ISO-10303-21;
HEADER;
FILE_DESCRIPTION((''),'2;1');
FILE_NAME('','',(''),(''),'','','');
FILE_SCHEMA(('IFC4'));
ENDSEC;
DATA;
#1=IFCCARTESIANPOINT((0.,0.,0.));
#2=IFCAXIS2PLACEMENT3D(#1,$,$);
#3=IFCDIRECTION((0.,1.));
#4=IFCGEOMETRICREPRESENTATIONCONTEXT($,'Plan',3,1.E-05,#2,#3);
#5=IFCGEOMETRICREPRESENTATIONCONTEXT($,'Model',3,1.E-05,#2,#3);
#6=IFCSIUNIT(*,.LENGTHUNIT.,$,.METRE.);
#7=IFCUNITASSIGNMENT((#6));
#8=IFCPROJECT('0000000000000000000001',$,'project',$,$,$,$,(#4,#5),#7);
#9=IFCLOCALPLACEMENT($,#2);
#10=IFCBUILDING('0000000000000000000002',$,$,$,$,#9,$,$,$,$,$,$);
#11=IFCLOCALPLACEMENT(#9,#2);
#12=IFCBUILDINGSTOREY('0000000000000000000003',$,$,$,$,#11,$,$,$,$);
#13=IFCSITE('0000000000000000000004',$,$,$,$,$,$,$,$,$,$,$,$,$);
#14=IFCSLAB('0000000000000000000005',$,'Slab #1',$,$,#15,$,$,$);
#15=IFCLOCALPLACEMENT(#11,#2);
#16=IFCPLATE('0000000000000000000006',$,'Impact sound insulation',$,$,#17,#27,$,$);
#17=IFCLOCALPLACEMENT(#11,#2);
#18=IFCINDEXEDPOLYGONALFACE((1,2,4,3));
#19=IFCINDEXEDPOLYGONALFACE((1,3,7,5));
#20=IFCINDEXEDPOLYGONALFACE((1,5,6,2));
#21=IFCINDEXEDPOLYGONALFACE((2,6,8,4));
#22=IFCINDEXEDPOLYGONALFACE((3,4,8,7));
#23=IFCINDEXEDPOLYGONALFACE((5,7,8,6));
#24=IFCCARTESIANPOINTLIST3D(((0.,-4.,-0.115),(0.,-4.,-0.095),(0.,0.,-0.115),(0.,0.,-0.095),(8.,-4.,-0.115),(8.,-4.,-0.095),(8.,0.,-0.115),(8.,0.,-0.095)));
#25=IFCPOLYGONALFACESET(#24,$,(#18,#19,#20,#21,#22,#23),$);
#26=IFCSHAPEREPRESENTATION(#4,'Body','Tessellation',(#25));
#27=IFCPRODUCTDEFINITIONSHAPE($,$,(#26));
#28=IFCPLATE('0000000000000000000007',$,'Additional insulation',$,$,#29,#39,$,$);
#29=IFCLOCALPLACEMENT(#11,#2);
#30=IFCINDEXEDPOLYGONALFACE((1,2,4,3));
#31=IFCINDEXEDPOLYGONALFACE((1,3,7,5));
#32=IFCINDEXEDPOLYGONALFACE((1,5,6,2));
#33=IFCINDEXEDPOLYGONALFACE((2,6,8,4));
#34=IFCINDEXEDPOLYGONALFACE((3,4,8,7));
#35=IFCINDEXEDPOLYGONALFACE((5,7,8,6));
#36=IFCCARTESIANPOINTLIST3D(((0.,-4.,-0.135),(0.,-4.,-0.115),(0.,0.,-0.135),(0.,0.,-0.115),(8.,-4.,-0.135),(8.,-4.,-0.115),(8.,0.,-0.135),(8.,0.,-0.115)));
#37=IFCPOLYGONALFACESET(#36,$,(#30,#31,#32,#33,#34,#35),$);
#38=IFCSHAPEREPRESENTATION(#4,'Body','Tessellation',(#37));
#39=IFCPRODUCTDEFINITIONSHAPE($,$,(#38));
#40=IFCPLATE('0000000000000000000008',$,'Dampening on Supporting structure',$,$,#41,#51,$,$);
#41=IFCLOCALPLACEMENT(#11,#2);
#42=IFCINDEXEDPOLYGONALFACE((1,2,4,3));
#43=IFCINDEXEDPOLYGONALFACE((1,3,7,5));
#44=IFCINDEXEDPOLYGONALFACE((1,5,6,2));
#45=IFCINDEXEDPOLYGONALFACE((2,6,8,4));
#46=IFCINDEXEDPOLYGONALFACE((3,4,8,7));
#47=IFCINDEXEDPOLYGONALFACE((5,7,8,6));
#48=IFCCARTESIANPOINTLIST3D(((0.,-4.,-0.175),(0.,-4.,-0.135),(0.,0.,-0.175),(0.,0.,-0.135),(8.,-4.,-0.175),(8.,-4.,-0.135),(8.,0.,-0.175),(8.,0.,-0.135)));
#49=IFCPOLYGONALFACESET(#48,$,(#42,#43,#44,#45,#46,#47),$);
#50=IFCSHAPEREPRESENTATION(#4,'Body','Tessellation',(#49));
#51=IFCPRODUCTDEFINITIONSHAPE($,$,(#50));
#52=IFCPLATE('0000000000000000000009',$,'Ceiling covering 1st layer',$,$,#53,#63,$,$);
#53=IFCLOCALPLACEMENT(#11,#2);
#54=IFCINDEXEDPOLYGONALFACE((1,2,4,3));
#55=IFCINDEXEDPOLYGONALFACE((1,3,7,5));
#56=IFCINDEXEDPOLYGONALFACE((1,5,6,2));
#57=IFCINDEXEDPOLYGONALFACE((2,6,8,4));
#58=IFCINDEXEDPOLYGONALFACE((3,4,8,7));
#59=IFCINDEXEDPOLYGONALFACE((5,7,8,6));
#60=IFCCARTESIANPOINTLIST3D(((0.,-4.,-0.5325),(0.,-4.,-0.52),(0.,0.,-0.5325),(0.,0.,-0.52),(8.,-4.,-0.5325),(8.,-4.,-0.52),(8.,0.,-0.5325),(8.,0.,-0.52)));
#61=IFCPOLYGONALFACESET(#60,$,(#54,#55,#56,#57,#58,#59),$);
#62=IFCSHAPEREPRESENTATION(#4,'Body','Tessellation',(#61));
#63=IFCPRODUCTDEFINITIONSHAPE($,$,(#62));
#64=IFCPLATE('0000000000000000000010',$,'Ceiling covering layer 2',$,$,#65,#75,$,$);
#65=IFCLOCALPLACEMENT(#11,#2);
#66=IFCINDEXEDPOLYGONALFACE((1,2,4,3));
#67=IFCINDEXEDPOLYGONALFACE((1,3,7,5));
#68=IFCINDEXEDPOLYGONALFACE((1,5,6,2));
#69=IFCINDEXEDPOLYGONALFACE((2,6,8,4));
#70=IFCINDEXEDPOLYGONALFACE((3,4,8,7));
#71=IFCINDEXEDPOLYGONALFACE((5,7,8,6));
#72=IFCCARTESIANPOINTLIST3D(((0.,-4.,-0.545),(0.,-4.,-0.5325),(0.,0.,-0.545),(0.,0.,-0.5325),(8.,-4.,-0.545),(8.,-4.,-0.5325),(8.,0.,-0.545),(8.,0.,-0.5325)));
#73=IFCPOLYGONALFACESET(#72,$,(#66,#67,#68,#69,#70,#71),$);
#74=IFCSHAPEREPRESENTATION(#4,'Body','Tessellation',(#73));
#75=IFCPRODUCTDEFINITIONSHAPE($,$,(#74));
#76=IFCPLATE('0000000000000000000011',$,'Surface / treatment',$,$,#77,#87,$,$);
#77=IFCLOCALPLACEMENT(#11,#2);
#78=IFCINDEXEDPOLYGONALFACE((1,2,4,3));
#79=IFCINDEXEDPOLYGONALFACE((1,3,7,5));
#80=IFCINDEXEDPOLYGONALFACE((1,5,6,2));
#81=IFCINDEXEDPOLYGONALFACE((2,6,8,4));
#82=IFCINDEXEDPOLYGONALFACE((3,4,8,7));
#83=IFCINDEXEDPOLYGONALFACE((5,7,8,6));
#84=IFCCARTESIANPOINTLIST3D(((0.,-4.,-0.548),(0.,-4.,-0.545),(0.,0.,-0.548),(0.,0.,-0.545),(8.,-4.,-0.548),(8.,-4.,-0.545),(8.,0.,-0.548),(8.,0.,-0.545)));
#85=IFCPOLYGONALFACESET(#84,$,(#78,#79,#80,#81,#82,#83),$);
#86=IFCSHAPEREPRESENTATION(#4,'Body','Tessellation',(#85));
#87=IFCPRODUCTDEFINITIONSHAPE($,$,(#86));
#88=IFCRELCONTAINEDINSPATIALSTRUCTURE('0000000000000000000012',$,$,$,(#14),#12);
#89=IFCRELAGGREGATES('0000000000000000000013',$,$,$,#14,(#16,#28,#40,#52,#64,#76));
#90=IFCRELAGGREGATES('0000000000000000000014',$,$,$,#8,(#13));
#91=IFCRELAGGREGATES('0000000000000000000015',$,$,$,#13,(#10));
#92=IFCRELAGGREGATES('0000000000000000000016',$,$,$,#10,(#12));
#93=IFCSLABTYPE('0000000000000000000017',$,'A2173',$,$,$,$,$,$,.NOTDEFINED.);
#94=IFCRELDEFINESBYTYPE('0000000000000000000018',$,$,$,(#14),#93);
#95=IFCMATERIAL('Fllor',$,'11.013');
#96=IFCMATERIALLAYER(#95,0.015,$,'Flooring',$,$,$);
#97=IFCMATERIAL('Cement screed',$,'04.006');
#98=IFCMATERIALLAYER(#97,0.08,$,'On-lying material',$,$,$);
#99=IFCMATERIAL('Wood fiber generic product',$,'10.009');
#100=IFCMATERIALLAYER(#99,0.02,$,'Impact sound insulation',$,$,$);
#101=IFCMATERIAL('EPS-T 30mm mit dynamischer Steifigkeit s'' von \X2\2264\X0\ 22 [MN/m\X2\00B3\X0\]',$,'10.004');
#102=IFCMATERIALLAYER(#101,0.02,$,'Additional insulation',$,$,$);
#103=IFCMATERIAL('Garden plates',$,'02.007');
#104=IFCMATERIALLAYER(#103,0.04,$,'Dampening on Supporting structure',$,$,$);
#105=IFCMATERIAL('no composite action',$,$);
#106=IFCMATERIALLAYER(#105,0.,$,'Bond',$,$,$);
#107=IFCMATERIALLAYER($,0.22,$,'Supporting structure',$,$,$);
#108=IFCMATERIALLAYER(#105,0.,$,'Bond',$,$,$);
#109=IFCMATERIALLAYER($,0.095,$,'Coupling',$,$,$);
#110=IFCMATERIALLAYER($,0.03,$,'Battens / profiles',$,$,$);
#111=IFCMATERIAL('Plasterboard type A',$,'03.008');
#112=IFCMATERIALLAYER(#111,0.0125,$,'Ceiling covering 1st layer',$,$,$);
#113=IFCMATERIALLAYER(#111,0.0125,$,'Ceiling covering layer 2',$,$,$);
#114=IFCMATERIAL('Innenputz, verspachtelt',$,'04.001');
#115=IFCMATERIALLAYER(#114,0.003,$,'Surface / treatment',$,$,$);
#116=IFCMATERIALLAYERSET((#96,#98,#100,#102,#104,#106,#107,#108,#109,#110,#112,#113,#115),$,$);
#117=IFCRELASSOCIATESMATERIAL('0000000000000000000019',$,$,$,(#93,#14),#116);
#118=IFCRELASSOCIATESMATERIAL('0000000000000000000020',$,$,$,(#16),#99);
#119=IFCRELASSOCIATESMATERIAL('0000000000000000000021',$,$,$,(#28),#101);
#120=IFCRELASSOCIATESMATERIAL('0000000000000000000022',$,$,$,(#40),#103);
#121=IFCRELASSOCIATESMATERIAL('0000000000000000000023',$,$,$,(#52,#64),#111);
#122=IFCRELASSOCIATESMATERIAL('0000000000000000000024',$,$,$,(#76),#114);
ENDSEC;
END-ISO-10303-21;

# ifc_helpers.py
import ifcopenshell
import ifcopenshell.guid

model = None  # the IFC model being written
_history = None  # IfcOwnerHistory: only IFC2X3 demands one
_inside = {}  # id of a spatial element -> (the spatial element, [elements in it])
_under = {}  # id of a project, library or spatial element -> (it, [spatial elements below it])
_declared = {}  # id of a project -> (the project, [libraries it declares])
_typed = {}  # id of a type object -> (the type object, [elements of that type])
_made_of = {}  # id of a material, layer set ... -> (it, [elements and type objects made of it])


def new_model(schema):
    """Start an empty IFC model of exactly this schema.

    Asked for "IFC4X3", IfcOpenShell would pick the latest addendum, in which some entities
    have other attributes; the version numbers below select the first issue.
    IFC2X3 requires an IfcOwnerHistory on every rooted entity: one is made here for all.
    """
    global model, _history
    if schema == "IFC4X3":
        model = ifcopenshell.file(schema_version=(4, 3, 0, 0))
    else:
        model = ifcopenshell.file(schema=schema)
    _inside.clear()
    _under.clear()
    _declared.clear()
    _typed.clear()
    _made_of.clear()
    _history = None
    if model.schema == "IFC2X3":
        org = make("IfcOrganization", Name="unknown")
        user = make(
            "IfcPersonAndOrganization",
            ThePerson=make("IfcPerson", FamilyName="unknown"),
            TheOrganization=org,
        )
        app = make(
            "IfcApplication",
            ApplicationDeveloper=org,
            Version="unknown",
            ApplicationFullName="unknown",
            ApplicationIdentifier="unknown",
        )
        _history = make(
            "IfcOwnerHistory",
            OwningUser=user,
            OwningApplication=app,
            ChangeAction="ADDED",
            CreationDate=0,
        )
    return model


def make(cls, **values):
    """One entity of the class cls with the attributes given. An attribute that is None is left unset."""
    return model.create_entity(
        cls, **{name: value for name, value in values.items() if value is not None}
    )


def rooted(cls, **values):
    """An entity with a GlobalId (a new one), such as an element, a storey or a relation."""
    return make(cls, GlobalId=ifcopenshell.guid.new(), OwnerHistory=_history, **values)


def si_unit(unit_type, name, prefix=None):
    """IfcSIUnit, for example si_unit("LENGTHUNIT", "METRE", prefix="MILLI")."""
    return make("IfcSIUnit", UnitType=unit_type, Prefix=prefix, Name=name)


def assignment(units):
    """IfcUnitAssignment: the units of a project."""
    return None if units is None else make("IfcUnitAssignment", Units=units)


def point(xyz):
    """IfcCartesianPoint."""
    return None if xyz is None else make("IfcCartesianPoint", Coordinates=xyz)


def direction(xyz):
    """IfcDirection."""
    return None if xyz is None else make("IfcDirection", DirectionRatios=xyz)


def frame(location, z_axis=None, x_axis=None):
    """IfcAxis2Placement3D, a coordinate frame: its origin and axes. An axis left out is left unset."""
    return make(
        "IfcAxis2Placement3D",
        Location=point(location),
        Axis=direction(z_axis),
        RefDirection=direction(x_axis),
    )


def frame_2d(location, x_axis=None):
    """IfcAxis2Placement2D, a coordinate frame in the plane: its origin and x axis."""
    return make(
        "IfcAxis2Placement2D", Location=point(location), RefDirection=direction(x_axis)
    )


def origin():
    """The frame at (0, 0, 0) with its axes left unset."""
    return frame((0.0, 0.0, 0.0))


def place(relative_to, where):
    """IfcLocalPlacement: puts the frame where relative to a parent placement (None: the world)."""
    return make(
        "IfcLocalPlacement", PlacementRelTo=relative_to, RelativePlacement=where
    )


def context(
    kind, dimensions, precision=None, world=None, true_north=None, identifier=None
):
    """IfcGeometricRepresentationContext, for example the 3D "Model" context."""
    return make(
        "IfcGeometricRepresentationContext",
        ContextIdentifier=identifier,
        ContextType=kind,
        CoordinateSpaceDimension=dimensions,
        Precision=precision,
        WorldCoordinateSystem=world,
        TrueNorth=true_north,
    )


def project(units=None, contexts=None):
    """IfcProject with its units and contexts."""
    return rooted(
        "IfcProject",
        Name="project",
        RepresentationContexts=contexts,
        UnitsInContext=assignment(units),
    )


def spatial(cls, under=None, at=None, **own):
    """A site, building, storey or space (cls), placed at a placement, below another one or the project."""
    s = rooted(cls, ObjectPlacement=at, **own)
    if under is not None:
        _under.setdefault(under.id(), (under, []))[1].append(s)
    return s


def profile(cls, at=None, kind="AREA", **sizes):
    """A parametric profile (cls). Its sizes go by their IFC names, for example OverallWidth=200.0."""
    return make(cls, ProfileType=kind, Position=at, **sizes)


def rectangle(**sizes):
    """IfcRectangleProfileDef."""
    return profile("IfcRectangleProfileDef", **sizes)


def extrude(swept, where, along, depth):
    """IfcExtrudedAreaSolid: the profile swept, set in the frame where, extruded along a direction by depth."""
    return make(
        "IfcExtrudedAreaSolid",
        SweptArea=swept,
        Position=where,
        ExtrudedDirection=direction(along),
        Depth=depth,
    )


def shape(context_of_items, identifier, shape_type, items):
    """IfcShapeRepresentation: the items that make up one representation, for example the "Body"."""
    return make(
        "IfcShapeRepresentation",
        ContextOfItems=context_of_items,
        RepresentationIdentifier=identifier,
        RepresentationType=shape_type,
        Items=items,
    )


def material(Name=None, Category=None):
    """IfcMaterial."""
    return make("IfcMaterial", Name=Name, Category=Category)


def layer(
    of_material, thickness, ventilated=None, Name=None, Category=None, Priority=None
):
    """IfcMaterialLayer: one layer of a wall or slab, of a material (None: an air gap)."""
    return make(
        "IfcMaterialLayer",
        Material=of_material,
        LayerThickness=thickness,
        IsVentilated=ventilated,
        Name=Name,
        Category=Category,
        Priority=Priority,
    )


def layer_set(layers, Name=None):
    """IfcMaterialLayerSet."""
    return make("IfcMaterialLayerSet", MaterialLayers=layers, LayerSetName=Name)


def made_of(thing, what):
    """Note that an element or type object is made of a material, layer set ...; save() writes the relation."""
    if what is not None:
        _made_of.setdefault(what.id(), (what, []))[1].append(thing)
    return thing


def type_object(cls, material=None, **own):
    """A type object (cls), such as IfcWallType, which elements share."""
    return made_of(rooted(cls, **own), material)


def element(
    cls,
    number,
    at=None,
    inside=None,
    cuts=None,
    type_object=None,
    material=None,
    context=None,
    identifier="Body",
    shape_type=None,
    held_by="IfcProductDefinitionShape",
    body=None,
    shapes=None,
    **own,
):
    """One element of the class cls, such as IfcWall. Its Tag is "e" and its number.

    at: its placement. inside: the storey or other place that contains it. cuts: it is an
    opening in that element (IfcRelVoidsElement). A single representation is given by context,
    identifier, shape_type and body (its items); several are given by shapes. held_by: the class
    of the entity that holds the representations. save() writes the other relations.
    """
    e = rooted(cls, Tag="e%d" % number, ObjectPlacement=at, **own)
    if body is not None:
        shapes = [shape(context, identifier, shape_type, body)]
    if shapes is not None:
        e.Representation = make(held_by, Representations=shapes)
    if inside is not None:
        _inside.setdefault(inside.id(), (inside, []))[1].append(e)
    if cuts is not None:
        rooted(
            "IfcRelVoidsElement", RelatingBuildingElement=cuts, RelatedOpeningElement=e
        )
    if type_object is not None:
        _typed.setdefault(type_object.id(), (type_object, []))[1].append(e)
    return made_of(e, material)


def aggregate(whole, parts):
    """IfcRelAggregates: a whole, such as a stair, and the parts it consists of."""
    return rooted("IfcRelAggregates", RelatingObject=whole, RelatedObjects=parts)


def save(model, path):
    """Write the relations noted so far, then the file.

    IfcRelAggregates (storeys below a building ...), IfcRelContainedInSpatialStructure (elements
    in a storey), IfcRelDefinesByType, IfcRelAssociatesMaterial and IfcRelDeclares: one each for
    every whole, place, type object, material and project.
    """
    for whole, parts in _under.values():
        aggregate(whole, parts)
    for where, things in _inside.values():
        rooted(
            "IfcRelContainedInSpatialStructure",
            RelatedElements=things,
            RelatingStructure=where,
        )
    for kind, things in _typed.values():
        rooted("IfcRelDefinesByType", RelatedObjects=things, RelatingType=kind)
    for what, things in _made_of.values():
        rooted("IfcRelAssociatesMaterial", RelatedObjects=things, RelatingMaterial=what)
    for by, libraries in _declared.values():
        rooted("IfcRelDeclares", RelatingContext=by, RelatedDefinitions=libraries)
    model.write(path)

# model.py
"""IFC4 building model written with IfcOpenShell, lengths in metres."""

from ifc_helpers import new_model, si_unit, direction, frame, frame_2d, origin, place, context, project, spatial, rectangle, extrude, material, layer, layer_set, type_object, element, aggregate, save


model = new_model("IFC4")

# Units and contexts
plan_context = context("Plan", 3, precision=1e-05, world=origin(), true_north=direction((0.0, 1.0)))
model_context = context("Model", 3, precision=1e-05, world=origin(), true_north=direction((0.0, 1.0)))
ifc_project = project(units=[si_unit("LENGTHUNIT", "METRE")], contexts=[plan_context, model_context])

# Site, building, storey
site = spatial("IfcSite", under=ifc_project)
building_placement = place(None, origin())
building = spatial("IfcBuilding", under=site, at=building_placement)
storey_placement = place(building_placement, origin())
storey = spatial("IfcBuildingStorey", under=building, at=storey_placement)

# Slab, plates
ifc_material_1 = material(Name="Fllor", Category="11.013")
ifc_layer_1 = layer(ifc_material_1, 0.015, Name="Flooring")
ifc_material_2 = material(Name="Cement screed", Category="04.006")
ifc_layer_2 = layer(ifc_material_2, 0.08, Name="On-lying material")
ifc_material_3 = material(Name="Wood fiber generic product", Category="10.009")
ifc_layer_3 = layer(ifc_material_3, 0.02, Name="Impact sound insulation")
ifc_material_4 = material(Name="EPS-T 30mm mit dynamischer Steifigkeit s' von ≤ 22 [MN/m³]", Category="10.004")
ifc_layer_4 = layer(ifc_material_4, 0.02, Name="Additional insulation")
ifc_material_5 = material(Name="Garden plates", Category="02.007")
ifc_layer_5 = layer(ifc_material_5, 0.04, Name="Dampening on Supporting structure")
ifc_material_6 = material(Name="no composite action")
ifc_layer_6 = layer(ifc_material_6, 0.0, Name="Bond")
ifc_layer_7 = layer(None, 0.22, Name="Supporting structure")
ifc_layer_8 = layer(ifc_material_6, 0.0, Name="Bond")
ifc_layer_9 = layer(None, 0.095, Name="Coupling")
ifc_layer_10 = layer(None, 0.03, Name="Battens / profiles")
ifc_material_7 = material(Name="Plasterboard type A", Category="03.008")
ifc_layer_11 = layer(ifc_material_7, 0.0125, Name="Ceiling covering 1st layer")
ifc_layer_12 = layer(ifc_material_7, 0.0125, Name="Ceiling covering layer 2")
ifc_material_8 = material(Name="Innenputz, verspachtelt", Category="04.001")
ifc_layer_13 = layer(ifc_material_8, 0.003, Name="Surface / treatment")
ifc_layer_set = layer_set([ifc_layer_1, ifc_layer_2, ifc_layer_3, ifc_layer_4, ifc_layer_5, ifc_layer_6, ifc_layer_7, ifc_layer_8, ifc_layer_9, ifc_layer_10, ifc_layer_11, ifc_layer_12, ifc_layer_13])
slab_type = type_object("IfcSlabType", Name="A2173", PredefinedType="NOTDEFINED", material=ifc_layer_set)
slab_placement = place(None, frame((0.0, 0.0, 0.0), z_axis=(0.0, 0.0, -1.0), x_axis=(1.0, 0.0, 0.0)))
slab = element("IfcSlab", 1, at=slab_placement, inside=storey, type_object=slab_type, material=ifc_layer_set, Name="Slab #1")
plate_1_placement = place(slab_placement, origin())
plate_1 = element("IfcPlate", 2, at=plate_1_placement, material=ifc_material_3, Name="Impact sound insulation", context=plan_context, shape_type="SweptSolid", body=[
    extrude(rectangle(XDim=8.0, YDim=4.0, at=frame_2d((4.0, 2.0), x_axis=(1.0, 0.0))), frame((0.0, 0.0, 0.095), z_axis=(0.0, 0.0, 1.0), x_axis=(1.0, 0.0, 0.0)), (0.0, 0.0, 1.0), 0.02),
])
plate_2_placement = place(slab_placement, origin())
plate_2 = element("IfcPlate", 3, at=plate_2_placement, material=ifc_material_4, Name="Additional insulation", context=plan_context, shape_type="SweptSolid", body=[
    extrude(rectangle(XDim=8.0, YDim=4.0, at=frame_2d((4.0, 2.0), x_axis=(1.0, 0.0))), frame((0.0, 0.0, 0.115), z_axis=(0.0, 0.0, 1.0), x_axis=(1.0, 0.0, 0.0)), (0.0, 0.0, 1.0), 0.02),
])
plate_3_placement = place(slab_placement, origin())
plate_3 = element("IfcPlate", 4, at=plate_3_placement, material=ifc_material_5, Name="Dampening on Supporting structure", context=plan_context, shape_type="SweptSolid", body=[
    extrude(rectangle(XDim=8.0, YDim=4.0, at=frame_2d((4.0, 2.0), x_axis=(1.0, 0.0))), frame((0.0, 0.0, 0.135), z_axis=(0.0, 0.0, 1.0), x_axis=(1.0, 0.0, 0.0)), (0.0, 0.0, 1.0), 0.04),
])
plate_4_placement = place(slab_placement, origin())
plate_4 = element("IfcPlate", 5, at=plate_4_placement, material=ifc_material_7, Name="Ceiling covering 1st layer", context=plan_context, shape_type="SweptSolid", body=[
    extrude(rectangle(XDim=8.0, YDim=4.0, at=frame_2d((4.0, 2.0), x_axis=(1.0, 0.0))), frame((0.0, 0.0, 0.52), z_axis=(0.0, 0.0, 1.0), x_axis=(1.0, 0.0, 0.0)), (0.0, 0.0, 1.0), 0.0125),
])
plate_5_placement = place(slab_placement, origin())
plate_5 = element("IfcPlate", 6, at=plate_5_placement, material=ifc_material_7, Name="Ceiling covering layer 2", context=plan_context, shape_type="SweptSolid", body=[
    extrude(rectangle(XDim=8.0, YDim=4.0, at=frame_2d((4.0, 2.0), x_axis=(1.0, 0.0))), frame((0.0, 0.0, 0.5325), z_axis=(0.0, 0.0, 1.0), x_axis=(1.0, 0.0, 0.0)), (0.0, 0.0, 1.0), 0.0125),
])
plate_6_placement = place(slab_placement, origin())
plate_6 = element("IfcPlate", 7, at=plate_6_placement, material=ifc_material_8, Name="Surface / treatment", context=plan_context, shape_type="SweptSolid", body=[
    extrude(rectangle(XDim=8.0, YDim=4.0, at=frame_2d((4.0, 2.0), x_axis=(1.0, 0.0))), frame((0.0, 0.0, 0.545), z_axis=(0.0, 0.0, 1.0), x_axis=(1.0, 0.0, 0.0)), (0.0, 0.0, 1.0), 0.003),
])
aggregate(slab, [plate_1, plate_2, plate_3, plate_4, plate_5, plate_6])

save(model, "model.ifc")
